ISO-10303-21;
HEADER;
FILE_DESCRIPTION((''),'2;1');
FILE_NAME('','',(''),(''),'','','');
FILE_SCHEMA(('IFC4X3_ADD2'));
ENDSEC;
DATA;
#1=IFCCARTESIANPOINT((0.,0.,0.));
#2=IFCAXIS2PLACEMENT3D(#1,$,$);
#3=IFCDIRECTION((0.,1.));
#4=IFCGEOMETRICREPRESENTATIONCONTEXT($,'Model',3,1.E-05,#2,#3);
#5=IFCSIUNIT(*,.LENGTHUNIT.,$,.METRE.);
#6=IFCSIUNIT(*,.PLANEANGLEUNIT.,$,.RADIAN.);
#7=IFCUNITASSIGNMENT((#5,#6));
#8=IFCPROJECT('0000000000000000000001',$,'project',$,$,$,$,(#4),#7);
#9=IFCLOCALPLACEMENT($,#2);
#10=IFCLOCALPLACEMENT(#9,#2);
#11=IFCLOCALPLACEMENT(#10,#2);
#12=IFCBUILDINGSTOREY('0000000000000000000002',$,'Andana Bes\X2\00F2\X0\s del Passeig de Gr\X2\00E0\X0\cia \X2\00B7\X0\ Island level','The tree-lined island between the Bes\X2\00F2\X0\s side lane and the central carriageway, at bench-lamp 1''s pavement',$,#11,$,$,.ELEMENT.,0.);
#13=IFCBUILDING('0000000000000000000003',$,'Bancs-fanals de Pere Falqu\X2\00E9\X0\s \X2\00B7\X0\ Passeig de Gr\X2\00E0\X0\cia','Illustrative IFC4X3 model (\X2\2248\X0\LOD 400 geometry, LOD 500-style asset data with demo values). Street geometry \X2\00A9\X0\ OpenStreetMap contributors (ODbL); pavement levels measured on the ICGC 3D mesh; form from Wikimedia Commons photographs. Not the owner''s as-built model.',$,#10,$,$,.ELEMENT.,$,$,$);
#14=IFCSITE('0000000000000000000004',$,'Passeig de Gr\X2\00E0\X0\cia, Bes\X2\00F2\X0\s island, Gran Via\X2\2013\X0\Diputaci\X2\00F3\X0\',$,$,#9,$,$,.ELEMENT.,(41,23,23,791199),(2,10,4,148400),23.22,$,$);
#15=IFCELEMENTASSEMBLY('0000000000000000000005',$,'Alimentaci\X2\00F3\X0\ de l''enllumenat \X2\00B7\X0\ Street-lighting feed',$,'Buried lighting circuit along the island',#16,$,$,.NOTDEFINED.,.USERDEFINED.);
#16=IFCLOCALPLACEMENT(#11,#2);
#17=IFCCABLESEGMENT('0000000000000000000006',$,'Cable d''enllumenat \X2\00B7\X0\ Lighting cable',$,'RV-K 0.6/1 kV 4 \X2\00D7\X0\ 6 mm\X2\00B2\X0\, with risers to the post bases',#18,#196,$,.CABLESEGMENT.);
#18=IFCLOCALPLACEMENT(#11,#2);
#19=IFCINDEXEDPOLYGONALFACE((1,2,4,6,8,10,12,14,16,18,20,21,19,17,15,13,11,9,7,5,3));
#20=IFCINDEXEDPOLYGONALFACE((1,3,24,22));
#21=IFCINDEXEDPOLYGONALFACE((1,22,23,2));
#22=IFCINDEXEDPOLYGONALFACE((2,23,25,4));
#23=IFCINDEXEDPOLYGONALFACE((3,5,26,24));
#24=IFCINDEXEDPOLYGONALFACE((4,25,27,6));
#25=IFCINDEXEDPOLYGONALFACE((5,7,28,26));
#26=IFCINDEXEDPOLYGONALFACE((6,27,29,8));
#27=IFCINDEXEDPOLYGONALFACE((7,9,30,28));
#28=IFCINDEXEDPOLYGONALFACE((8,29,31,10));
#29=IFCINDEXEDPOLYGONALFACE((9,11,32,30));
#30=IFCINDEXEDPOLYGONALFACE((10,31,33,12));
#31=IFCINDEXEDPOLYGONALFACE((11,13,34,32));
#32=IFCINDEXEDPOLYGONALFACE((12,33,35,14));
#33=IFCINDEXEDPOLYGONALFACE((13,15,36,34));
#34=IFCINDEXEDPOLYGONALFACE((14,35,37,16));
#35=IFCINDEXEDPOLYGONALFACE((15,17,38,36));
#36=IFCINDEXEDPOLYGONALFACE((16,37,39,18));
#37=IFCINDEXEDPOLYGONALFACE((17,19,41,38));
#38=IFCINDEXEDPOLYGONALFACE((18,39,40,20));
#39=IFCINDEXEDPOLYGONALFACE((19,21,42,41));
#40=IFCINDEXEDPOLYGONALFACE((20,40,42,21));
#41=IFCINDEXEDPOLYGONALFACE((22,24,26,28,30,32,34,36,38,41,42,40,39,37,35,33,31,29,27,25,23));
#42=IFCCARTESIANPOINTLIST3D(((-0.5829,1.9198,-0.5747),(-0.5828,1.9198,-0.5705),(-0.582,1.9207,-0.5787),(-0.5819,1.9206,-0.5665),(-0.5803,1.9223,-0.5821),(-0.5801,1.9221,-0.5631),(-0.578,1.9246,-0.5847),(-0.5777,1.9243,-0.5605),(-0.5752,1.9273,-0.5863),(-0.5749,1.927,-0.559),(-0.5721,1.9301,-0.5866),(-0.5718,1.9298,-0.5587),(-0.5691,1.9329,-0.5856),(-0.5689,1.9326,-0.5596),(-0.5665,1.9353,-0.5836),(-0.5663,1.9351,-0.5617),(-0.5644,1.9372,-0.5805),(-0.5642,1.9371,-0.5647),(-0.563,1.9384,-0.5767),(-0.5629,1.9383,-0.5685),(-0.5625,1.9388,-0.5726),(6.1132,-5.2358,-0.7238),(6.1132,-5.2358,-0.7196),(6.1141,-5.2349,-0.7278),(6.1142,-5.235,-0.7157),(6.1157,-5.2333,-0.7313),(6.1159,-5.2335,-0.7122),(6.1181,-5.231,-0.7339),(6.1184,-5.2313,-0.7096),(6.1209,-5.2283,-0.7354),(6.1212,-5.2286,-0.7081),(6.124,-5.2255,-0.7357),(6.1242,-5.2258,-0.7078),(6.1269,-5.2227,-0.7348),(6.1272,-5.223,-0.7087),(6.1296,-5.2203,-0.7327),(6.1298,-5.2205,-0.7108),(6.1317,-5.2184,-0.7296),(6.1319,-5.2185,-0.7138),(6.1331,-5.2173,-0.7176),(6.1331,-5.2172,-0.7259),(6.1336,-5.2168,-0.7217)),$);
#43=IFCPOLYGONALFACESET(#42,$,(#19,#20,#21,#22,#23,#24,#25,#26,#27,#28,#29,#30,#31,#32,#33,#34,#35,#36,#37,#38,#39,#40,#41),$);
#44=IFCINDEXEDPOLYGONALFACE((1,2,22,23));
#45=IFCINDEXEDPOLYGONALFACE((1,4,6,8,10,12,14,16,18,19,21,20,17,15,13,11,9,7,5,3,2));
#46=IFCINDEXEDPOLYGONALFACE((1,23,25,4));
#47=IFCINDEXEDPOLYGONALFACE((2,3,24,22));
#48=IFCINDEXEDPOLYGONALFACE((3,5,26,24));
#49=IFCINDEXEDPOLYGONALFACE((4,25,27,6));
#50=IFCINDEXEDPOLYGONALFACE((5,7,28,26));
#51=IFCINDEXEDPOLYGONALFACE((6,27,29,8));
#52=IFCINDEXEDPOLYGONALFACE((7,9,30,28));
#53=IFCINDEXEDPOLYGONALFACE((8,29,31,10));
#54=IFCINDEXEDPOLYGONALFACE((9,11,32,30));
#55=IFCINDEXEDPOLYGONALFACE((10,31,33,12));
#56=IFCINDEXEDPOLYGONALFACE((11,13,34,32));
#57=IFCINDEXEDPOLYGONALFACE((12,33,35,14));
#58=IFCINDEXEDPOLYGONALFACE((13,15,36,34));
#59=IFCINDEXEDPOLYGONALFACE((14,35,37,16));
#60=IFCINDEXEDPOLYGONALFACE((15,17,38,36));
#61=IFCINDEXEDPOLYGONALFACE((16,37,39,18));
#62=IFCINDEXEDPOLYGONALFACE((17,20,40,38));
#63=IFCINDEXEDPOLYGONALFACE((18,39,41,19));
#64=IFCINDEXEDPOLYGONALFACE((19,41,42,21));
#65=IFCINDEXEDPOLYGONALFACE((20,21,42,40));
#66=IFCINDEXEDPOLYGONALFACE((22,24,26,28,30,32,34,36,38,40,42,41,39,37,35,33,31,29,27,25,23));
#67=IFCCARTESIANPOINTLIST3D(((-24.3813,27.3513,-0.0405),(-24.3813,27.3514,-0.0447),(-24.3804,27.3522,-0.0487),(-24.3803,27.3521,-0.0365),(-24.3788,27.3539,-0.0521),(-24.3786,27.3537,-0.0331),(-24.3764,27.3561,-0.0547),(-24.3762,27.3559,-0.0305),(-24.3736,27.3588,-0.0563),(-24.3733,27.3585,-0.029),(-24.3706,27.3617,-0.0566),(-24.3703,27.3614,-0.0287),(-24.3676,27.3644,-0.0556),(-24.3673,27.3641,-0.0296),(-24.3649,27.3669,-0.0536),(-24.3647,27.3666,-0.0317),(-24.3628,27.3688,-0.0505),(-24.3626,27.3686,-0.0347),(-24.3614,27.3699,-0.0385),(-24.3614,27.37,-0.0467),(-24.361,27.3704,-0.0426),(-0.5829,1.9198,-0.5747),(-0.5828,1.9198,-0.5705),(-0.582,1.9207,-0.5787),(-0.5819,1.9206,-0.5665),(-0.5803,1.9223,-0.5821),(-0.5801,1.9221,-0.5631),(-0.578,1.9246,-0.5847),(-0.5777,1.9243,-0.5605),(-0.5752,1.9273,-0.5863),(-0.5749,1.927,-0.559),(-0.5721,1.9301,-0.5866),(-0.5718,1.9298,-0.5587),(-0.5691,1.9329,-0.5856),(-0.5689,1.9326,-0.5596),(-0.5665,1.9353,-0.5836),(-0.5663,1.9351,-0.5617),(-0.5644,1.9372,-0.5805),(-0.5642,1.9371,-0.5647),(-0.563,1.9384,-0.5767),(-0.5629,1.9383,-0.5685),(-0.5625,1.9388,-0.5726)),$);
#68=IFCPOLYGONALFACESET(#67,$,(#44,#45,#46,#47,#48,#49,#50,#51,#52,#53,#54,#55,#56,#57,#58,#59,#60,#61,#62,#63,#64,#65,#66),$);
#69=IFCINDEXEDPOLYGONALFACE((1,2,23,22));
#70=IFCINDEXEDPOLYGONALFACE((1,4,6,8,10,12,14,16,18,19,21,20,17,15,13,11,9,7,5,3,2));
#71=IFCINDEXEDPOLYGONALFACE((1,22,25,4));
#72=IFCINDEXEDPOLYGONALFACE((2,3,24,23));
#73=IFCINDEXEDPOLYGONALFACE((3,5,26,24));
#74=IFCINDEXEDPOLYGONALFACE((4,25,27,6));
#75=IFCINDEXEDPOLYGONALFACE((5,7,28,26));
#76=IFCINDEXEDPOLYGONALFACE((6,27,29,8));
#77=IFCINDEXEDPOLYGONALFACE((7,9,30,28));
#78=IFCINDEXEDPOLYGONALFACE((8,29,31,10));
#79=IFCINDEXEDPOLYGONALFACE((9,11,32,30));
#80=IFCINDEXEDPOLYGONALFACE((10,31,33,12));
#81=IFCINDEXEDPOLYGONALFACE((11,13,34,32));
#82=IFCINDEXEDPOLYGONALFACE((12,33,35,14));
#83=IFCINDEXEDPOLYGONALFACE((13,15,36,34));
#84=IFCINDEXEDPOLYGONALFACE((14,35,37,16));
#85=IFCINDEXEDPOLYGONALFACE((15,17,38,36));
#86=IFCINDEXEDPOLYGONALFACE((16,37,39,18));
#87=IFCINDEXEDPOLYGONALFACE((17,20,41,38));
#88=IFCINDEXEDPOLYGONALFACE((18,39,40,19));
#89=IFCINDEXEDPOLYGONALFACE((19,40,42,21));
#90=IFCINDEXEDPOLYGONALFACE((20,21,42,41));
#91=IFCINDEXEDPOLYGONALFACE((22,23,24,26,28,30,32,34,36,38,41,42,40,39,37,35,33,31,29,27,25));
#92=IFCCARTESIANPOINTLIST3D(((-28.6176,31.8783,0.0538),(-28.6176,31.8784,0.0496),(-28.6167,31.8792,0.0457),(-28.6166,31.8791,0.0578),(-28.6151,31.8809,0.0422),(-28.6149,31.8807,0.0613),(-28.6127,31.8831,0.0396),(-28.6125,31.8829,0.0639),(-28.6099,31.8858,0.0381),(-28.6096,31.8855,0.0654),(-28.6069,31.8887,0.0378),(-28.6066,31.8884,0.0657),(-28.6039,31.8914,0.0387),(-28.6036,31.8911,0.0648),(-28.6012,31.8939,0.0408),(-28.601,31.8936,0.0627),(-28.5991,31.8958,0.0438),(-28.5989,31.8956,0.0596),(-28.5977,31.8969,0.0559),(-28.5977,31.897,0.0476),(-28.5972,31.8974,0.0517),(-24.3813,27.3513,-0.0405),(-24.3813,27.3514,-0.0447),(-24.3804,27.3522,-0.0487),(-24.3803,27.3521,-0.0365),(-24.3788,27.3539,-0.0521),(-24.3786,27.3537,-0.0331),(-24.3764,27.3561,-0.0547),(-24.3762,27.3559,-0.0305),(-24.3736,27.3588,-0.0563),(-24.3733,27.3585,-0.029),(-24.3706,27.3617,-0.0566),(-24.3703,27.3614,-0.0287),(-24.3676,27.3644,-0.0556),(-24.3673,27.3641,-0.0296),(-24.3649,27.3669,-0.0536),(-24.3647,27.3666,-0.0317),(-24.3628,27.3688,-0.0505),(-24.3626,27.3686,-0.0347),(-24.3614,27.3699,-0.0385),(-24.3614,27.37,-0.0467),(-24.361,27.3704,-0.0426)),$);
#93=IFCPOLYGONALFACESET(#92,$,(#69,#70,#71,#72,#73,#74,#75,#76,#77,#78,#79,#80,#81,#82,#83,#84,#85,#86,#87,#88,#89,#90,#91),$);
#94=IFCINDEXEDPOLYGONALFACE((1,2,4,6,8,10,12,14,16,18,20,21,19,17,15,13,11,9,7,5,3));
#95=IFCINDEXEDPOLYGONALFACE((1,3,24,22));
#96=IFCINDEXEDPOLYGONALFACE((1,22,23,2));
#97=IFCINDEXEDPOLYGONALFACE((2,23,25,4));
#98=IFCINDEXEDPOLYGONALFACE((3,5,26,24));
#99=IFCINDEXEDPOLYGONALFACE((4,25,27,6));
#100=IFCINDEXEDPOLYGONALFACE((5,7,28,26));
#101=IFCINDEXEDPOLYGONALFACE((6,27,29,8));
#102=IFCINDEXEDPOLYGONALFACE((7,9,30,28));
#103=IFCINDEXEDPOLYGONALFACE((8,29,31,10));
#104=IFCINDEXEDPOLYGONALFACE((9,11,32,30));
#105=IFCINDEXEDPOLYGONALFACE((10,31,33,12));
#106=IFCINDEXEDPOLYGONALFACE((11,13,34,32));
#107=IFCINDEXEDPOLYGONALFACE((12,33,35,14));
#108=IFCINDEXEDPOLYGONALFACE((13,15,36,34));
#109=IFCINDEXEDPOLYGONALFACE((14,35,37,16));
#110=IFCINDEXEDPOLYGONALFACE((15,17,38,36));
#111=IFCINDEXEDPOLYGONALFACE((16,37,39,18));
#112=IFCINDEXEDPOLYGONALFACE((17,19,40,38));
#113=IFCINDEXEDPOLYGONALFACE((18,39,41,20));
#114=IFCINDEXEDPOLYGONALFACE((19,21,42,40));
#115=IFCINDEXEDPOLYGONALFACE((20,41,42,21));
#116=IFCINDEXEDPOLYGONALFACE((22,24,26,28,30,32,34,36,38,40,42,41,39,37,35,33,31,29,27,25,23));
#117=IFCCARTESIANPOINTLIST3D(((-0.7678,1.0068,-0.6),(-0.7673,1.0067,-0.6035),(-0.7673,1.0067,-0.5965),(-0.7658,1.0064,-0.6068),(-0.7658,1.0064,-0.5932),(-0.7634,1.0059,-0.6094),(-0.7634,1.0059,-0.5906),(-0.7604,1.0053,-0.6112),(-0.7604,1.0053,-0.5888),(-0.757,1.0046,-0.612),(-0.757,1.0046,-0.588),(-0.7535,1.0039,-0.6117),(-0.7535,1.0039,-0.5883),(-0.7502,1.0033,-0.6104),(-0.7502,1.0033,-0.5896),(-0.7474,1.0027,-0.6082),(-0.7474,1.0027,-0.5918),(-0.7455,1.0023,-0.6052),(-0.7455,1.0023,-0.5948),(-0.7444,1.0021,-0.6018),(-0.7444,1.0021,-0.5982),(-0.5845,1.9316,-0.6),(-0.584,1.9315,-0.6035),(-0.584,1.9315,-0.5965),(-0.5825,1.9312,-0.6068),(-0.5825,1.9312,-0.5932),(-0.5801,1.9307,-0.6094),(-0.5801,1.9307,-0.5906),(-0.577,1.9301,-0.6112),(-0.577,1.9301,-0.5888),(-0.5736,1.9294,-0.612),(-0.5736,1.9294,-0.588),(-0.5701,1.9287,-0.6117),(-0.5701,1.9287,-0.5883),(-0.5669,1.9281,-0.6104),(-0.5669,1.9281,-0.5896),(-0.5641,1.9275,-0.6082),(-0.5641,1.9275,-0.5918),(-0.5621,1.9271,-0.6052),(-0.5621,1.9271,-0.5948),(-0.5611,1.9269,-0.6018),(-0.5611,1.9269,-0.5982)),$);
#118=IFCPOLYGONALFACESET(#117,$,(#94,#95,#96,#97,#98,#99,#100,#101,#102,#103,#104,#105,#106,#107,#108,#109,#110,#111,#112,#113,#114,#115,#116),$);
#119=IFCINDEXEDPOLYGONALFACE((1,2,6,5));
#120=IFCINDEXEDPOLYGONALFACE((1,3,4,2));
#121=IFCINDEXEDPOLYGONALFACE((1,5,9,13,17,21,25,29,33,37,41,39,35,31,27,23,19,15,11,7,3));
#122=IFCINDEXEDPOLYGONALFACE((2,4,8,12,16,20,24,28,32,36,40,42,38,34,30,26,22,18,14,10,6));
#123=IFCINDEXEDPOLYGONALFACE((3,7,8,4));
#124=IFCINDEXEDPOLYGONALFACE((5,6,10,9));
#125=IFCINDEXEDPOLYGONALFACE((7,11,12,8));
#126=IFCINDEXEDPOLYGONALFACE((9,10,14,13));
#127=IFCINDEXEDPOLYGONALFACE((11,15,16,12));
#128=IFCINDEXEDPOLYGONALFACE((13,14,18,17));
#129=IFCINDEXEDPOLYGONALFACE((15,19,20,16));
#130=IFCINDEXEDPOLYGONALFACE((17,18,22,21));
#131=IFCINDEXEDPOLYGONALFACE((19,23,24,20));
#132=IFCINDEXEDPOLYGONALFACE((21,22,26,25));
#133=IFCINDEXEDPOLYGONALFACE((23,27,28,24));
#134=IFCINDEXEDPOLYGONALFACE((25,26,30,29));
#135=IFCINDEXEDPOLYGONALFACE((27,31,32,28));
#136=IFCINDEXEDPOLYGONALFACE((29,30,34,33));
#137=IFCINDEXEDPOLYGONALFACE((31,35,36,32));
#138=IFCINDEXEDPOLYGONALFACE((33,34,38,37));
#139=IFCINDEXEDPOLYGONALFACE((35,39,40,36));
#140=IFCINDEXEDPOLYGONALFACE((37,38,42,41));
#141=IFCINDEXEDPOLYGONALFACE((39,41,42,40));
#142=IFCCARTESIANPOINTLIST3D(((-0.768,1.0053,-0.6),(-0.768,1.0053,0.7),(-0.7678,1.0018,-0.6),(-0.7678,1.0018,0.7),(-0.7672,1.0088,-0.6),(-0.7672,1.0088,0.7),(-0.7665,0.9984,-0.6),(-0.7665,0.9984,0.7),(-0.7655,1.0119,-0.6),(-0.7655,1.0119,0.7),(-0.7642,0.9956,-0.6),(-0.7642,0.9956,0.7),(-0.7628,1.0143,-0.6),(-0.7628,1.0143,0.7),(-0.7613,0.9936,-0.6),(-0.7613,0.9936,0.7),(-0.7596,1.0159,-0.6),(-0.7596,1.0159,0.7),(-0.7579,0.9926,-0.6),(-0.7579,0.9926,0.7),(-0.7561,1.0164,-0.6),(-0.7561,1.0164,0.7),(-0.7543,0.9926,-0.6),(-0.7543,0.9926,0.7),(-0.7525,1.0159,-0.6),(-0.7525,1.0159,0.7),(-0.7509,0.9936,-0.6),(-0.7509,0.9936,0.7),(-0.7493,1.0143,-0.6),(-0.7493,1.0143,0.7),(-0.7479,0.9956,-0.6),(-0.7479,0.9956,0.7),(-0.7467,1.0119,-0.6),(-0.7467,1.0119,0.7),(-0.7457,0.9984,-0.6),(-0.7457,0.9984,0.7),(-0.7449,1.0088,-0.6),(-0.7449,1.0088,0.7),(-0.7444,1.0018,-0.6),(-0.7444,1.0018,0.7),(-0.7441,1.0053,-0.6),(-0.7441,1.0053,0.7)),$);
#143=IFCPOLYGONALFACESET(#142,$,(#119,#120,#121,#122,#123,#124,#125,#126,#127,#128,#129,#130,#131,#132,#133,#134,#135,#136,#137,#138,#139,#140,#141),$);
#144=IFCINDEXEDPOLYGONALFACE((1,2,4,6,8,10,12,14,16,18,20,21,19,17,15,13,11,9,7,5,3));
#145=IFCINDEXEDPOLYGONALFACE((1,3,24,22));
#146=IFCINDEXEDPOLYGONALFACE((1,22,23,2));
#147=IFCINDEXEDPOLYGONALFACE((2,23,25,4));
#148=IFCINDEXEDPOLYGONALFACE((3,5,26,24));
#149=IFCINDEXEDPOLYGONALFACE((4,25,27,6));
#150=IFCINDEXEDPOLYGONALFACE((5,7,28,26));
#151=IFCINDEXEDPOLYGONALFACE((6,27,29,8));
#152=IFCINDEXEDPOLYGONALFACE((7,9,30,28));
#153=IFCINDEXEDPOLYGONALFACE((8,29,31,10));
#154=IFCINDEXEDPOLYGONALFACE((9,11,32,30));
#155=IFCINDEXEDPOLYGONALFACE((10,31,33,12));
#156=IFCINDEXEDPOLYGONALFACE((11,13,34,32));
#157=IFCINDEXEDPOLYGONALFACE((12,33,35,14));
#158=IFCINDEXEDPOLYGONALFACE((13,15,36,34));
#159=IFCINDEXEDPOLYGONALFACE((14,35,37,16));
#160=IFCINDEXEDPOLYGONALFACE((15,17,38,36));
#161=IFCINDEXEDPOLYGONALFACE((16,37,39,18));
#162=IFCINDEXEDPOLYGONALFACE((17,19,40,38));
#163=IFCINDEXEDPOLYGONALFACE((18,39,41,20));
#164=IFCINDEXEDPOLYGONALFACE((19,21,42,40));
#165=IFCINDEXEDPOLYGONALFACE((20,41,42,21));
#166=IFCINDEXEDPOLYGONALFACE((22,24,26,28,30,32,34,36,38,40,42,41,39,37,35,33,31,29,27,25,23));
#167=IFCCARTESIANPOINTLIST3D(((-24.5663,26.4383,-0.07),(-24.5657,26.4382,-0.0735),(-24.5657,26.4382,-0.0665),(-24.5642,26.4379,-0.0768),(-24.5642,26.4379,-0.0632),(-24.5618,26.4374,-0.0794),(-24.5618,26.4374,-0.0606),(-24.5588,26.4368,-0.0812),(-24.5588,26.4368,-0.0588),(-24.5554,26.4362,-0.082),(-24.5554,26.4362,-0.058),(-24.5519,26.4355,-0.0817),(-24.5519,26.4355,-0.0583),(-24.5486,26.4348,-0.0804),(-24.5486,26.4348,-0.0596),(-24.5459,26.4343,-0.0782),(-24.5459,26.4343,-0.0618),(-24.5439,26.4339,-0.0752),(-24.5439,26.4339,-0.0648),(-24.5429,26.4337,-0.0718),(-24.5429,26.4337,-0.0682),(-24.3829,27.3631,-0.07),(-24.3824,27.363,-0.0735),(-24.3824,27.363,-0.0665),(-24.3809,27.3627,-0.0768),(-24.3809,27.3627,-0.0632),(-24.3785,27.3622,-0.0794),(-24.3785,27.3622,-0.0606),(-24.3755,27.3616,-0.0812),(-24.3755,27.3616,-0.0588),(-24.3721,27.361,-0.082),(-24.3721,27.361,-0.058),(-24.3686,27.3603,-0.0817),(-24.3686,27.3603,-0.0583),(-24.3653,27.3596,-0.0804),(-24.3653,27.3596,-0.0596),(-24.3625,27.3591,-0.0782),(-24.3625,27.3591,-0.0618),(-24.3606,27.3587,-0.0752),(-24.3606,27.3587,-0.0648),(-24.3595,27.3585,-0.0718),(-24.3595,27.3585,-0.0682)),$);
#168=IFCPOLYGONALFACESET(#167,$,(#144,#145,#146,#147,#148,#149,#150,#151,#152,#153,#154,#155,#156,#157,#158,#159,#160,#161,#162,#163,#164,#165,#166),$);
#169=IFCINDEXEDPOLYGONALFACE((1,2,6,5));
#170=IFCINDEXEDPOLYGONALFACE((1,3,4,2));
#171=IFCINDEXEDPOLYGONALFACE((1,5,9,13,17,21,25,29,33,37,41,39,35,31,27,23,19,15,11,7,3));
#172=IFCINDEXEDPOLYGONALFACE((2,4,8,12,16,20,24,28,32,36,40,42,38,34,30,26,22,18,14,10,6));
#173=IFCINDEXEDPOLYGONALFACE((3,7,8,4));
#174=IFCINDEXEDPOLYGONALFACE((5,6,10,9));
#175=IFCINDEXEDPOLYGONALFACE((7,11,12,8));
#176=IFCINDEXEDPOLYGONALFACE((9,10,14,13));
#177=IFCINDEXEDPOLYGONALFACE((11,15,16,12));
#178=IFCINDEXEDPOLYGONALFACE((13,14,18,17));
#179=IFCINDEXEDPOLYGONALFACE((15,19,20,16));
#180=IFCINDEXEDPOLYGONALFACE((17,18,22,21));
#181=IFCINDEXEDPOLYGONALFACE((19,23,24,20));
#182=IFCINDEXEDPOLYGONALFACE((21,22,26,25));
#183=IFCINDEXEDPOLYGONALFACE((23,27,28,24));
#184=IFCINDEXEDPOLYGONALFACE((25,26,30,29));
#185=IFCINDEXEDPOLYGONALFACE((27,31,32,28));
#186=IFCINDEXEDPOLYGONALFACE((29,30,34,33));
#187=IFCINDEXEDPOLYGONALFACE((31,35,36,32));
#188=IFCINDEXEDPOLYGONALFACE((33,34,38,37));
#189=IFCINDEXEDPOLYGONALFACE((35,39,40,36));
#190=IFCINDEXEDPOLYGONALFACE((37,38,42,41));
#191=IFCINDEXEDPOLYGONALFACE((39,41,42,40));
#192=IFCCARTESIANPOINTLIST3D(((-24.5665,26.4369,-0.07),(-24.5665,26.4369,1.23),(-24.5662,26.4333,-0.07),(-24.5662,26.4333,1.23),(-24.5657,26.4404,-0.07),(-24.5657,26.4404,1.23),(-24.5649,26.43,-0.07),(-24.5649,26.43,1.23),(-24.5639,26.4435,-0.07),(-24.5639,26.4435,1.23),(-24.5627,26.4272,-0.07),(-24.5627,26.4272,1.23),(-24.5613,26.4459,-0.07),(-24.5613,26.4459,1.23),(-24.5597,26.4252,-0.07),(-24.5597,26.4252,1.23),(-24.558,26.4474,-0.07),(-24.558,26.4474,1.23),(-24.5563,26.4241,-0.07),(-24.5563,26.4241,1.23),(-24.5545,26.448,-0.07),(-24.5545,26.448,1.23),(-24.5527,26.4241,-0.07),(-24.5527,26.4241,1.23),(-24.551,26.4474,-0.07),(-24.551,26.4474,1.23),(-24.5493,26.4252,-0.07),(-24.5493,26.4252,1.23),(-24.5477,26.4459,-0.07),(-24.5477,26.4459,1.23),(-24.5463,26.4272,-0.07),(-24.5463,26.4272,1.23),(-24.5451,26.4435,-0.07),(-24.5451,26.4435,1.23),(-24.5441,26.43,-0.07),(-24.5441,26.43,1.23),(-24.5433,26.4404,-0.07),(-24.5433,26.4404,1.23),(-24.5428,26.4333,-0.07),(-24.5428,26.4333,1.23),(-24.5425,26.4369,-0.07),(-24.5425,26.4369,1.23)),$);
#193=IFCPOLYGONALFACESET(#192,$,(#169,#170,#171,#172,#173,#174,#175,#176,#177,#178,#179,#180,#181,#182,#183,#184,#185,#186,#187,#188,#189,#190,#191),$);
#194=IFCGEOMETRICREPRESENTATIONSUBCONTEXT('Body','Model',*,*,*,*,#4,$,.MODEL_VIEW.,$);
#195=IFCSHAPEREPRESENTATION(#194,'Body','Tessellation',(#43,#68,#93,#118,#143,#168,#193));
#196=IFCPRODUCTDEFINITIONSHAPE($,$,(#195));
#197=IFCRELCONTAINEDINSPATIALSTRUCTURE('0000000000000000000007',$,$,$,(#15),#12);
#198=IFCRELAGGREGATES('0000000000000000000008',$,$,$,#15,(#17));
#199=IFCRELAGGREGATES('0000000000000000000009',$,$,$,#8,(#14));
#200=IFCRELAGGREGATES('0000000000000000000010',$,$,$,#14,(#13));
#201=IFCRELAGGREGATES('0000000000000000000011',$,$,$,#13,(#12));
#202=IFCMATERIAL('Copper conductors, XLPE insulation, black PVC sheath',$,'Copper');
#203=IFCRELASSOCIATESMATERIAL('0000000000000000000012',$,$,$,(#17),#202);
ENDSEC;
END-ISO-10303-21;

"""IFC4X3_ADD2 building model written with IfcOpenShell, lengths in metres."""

from ifc_helpers import new_model, si_unit, direction, frame, origin, origin_2d_with_axis, place, context, subcontext, project, spatial, circle, extrude, material, element, aggregate, save


model = new_model("IFC4X3_ADD2")

# Units and contexts
model_context = context("Model", 3, precision=1e-05, world=origin(), true_north=direction((0.0, 1.0)))
body_context = subcontext(model_context, "Body", "Model", "MODEL_VIEW")
ifc_project = project(units=[si_unit("LENGTHUNIT", "METRE"), si_unit("PLANEANGLEUNIT", "RADIAN")], contexts=[model_context])

# Site, building, storey
site_placement = place(None, origin())
site = spatial("IfcSite", under=ifc_project, at=site_placement, Name="Passeig de Gràcia, Besòs island, Gran Via–Diputació", CompositionType="ELEMENT", RefLatitude=(41, 23, 23, 791199), RefLongitude=(2, 10, 4, 148400), RefElevation=23.22)
building_placement = place(site_placement, origin())
building = spatial("IfcBuilding", under=site, at=building_placement, Name="Bancs-fanals de Pere Falqués · Passeig de Gràcia", Description="Illustrative IFC4X3 model (≈LOD 400 geometry, LOD 500-style asset data with demo values). Street geometry © OpenStreetMap contributors (ODbL); pavement levels measured on the ICGC 3D mesh; form from Wikimedia Commons photographs. Not the owner's as-built model.", CompositionType="ELEMENT")
storey_placement = place(building_placement, origin())
storey = spatial("IfcBuildingStorey", under=building, at=storey_placement, Name="Andana Besòs del Passeig de Gràcia · Island level", Description="The tree-lined island between the Besòs side lane and the central carriageway, at bench-lamp 1's pavement", CompositionType="ELEMENT", Elevation=0.0)

# Element assembly
assembly_1_placement = place(building_placement, origin())
assembly_1 = element("IfcElementAssembly", 1, at=assembly_1_placement, inside=storey, Name="Alimentació de l'enllumenat · Street-lighting feed", ObjectType="Buried lighting circuit along the island", AssemblyPlace="NOTDEFINED", PredefinedType="USERDEFINED")

# Cable segment
ifc_material_1 = material(Name="Copper conductors, XLPE insulation, black PVC sheath", Category="Copper")
cable_segment_placement = place(building_placement, origin())
cable_segment = element("IfcCableSegment", 2, at=cable_segment_placement, material=ifc_material_1, Name="Cable d'enllumenat · Lighting cable", ObjectType="RV-K 0.6/1 kV 4 × 6 mm², with risers to the post bases", PredefinedType="CABLESEGMENT", context=body_context, shape_type="SweptSolid", body=[
    extrude(circle(Radius=0.014, at=origin_2d_with_axis()), frame((6.1233, -5.2264, -0.7217), z_axis=(-0.683195, 0.730078, 0.015215), x_axis=(0.730162, 0.683274, 0.0)), (0.0, 0.0, 1.0), 9.8011),
    extrude(circle(Radius=0.014, at=origin_2d_with_axis()), frame((-0.5727, 1.9292, -0.5726), z_axis=(-0.683195, 0.730078, 0.015215), x_axis=(0.730162, 0.683274, 0.0)), (0.0, 0.0, 1.0), 34.834),
    extrude(circle(Radius=0.014, at=origin_2d_with_axis()), frame((-24.3712, 27.3608, -0.0426), z_axis=(-0.683195, 0.730078, 0.015215), x_axis=(0.730162, 0.683274, 0.0)), (0.0, 0.0, 1.0), 6.2007),
    extrude(circle(Radius=0.012, at=origin_2d_with_axis()), frame((-0.5727, 1.9292, -0.6), z_axis=(-0.194449, -0.980913, 0.0), x_axis=(-0.980913, 0.194449, 0.0)), (0.0, 0.0, 1.0), 0.9428),
    extrude(circle(Radius=0.012, at=origin_2d_with_axis()), frame((-0.7561, 1.0044, -0.6), z_axis=(0.0, 0.0, 1.0), x_axis=(0.0, 1.0, 0.0)), (0.0, 0.0, 1.0), 1.3),
    extrude(circle(Radius=0.012, at=origin_2d_with_axis()), frame((-24.3712, 27.3608, -0.07), z_axis=(-0.194449, -0.980913, 0.0), x_axis=(-0.980913, 0.194449, 0.0)), (0.0, 0.0, 1.0), 0.9428),
    extrude(circle(Radius=0.012, at=origin_2d_with_axis()), frame((-24.5545, 26.436, -0.07), z_axis=(0.0, 0.0, 1.0), x_axis=(0.0, 1.0, 0.0)), (0.0, 0.0, 1.0), 1.3),
])

aggregate(assembly_1, [cable_segment])

save(model, "model.ifc")
